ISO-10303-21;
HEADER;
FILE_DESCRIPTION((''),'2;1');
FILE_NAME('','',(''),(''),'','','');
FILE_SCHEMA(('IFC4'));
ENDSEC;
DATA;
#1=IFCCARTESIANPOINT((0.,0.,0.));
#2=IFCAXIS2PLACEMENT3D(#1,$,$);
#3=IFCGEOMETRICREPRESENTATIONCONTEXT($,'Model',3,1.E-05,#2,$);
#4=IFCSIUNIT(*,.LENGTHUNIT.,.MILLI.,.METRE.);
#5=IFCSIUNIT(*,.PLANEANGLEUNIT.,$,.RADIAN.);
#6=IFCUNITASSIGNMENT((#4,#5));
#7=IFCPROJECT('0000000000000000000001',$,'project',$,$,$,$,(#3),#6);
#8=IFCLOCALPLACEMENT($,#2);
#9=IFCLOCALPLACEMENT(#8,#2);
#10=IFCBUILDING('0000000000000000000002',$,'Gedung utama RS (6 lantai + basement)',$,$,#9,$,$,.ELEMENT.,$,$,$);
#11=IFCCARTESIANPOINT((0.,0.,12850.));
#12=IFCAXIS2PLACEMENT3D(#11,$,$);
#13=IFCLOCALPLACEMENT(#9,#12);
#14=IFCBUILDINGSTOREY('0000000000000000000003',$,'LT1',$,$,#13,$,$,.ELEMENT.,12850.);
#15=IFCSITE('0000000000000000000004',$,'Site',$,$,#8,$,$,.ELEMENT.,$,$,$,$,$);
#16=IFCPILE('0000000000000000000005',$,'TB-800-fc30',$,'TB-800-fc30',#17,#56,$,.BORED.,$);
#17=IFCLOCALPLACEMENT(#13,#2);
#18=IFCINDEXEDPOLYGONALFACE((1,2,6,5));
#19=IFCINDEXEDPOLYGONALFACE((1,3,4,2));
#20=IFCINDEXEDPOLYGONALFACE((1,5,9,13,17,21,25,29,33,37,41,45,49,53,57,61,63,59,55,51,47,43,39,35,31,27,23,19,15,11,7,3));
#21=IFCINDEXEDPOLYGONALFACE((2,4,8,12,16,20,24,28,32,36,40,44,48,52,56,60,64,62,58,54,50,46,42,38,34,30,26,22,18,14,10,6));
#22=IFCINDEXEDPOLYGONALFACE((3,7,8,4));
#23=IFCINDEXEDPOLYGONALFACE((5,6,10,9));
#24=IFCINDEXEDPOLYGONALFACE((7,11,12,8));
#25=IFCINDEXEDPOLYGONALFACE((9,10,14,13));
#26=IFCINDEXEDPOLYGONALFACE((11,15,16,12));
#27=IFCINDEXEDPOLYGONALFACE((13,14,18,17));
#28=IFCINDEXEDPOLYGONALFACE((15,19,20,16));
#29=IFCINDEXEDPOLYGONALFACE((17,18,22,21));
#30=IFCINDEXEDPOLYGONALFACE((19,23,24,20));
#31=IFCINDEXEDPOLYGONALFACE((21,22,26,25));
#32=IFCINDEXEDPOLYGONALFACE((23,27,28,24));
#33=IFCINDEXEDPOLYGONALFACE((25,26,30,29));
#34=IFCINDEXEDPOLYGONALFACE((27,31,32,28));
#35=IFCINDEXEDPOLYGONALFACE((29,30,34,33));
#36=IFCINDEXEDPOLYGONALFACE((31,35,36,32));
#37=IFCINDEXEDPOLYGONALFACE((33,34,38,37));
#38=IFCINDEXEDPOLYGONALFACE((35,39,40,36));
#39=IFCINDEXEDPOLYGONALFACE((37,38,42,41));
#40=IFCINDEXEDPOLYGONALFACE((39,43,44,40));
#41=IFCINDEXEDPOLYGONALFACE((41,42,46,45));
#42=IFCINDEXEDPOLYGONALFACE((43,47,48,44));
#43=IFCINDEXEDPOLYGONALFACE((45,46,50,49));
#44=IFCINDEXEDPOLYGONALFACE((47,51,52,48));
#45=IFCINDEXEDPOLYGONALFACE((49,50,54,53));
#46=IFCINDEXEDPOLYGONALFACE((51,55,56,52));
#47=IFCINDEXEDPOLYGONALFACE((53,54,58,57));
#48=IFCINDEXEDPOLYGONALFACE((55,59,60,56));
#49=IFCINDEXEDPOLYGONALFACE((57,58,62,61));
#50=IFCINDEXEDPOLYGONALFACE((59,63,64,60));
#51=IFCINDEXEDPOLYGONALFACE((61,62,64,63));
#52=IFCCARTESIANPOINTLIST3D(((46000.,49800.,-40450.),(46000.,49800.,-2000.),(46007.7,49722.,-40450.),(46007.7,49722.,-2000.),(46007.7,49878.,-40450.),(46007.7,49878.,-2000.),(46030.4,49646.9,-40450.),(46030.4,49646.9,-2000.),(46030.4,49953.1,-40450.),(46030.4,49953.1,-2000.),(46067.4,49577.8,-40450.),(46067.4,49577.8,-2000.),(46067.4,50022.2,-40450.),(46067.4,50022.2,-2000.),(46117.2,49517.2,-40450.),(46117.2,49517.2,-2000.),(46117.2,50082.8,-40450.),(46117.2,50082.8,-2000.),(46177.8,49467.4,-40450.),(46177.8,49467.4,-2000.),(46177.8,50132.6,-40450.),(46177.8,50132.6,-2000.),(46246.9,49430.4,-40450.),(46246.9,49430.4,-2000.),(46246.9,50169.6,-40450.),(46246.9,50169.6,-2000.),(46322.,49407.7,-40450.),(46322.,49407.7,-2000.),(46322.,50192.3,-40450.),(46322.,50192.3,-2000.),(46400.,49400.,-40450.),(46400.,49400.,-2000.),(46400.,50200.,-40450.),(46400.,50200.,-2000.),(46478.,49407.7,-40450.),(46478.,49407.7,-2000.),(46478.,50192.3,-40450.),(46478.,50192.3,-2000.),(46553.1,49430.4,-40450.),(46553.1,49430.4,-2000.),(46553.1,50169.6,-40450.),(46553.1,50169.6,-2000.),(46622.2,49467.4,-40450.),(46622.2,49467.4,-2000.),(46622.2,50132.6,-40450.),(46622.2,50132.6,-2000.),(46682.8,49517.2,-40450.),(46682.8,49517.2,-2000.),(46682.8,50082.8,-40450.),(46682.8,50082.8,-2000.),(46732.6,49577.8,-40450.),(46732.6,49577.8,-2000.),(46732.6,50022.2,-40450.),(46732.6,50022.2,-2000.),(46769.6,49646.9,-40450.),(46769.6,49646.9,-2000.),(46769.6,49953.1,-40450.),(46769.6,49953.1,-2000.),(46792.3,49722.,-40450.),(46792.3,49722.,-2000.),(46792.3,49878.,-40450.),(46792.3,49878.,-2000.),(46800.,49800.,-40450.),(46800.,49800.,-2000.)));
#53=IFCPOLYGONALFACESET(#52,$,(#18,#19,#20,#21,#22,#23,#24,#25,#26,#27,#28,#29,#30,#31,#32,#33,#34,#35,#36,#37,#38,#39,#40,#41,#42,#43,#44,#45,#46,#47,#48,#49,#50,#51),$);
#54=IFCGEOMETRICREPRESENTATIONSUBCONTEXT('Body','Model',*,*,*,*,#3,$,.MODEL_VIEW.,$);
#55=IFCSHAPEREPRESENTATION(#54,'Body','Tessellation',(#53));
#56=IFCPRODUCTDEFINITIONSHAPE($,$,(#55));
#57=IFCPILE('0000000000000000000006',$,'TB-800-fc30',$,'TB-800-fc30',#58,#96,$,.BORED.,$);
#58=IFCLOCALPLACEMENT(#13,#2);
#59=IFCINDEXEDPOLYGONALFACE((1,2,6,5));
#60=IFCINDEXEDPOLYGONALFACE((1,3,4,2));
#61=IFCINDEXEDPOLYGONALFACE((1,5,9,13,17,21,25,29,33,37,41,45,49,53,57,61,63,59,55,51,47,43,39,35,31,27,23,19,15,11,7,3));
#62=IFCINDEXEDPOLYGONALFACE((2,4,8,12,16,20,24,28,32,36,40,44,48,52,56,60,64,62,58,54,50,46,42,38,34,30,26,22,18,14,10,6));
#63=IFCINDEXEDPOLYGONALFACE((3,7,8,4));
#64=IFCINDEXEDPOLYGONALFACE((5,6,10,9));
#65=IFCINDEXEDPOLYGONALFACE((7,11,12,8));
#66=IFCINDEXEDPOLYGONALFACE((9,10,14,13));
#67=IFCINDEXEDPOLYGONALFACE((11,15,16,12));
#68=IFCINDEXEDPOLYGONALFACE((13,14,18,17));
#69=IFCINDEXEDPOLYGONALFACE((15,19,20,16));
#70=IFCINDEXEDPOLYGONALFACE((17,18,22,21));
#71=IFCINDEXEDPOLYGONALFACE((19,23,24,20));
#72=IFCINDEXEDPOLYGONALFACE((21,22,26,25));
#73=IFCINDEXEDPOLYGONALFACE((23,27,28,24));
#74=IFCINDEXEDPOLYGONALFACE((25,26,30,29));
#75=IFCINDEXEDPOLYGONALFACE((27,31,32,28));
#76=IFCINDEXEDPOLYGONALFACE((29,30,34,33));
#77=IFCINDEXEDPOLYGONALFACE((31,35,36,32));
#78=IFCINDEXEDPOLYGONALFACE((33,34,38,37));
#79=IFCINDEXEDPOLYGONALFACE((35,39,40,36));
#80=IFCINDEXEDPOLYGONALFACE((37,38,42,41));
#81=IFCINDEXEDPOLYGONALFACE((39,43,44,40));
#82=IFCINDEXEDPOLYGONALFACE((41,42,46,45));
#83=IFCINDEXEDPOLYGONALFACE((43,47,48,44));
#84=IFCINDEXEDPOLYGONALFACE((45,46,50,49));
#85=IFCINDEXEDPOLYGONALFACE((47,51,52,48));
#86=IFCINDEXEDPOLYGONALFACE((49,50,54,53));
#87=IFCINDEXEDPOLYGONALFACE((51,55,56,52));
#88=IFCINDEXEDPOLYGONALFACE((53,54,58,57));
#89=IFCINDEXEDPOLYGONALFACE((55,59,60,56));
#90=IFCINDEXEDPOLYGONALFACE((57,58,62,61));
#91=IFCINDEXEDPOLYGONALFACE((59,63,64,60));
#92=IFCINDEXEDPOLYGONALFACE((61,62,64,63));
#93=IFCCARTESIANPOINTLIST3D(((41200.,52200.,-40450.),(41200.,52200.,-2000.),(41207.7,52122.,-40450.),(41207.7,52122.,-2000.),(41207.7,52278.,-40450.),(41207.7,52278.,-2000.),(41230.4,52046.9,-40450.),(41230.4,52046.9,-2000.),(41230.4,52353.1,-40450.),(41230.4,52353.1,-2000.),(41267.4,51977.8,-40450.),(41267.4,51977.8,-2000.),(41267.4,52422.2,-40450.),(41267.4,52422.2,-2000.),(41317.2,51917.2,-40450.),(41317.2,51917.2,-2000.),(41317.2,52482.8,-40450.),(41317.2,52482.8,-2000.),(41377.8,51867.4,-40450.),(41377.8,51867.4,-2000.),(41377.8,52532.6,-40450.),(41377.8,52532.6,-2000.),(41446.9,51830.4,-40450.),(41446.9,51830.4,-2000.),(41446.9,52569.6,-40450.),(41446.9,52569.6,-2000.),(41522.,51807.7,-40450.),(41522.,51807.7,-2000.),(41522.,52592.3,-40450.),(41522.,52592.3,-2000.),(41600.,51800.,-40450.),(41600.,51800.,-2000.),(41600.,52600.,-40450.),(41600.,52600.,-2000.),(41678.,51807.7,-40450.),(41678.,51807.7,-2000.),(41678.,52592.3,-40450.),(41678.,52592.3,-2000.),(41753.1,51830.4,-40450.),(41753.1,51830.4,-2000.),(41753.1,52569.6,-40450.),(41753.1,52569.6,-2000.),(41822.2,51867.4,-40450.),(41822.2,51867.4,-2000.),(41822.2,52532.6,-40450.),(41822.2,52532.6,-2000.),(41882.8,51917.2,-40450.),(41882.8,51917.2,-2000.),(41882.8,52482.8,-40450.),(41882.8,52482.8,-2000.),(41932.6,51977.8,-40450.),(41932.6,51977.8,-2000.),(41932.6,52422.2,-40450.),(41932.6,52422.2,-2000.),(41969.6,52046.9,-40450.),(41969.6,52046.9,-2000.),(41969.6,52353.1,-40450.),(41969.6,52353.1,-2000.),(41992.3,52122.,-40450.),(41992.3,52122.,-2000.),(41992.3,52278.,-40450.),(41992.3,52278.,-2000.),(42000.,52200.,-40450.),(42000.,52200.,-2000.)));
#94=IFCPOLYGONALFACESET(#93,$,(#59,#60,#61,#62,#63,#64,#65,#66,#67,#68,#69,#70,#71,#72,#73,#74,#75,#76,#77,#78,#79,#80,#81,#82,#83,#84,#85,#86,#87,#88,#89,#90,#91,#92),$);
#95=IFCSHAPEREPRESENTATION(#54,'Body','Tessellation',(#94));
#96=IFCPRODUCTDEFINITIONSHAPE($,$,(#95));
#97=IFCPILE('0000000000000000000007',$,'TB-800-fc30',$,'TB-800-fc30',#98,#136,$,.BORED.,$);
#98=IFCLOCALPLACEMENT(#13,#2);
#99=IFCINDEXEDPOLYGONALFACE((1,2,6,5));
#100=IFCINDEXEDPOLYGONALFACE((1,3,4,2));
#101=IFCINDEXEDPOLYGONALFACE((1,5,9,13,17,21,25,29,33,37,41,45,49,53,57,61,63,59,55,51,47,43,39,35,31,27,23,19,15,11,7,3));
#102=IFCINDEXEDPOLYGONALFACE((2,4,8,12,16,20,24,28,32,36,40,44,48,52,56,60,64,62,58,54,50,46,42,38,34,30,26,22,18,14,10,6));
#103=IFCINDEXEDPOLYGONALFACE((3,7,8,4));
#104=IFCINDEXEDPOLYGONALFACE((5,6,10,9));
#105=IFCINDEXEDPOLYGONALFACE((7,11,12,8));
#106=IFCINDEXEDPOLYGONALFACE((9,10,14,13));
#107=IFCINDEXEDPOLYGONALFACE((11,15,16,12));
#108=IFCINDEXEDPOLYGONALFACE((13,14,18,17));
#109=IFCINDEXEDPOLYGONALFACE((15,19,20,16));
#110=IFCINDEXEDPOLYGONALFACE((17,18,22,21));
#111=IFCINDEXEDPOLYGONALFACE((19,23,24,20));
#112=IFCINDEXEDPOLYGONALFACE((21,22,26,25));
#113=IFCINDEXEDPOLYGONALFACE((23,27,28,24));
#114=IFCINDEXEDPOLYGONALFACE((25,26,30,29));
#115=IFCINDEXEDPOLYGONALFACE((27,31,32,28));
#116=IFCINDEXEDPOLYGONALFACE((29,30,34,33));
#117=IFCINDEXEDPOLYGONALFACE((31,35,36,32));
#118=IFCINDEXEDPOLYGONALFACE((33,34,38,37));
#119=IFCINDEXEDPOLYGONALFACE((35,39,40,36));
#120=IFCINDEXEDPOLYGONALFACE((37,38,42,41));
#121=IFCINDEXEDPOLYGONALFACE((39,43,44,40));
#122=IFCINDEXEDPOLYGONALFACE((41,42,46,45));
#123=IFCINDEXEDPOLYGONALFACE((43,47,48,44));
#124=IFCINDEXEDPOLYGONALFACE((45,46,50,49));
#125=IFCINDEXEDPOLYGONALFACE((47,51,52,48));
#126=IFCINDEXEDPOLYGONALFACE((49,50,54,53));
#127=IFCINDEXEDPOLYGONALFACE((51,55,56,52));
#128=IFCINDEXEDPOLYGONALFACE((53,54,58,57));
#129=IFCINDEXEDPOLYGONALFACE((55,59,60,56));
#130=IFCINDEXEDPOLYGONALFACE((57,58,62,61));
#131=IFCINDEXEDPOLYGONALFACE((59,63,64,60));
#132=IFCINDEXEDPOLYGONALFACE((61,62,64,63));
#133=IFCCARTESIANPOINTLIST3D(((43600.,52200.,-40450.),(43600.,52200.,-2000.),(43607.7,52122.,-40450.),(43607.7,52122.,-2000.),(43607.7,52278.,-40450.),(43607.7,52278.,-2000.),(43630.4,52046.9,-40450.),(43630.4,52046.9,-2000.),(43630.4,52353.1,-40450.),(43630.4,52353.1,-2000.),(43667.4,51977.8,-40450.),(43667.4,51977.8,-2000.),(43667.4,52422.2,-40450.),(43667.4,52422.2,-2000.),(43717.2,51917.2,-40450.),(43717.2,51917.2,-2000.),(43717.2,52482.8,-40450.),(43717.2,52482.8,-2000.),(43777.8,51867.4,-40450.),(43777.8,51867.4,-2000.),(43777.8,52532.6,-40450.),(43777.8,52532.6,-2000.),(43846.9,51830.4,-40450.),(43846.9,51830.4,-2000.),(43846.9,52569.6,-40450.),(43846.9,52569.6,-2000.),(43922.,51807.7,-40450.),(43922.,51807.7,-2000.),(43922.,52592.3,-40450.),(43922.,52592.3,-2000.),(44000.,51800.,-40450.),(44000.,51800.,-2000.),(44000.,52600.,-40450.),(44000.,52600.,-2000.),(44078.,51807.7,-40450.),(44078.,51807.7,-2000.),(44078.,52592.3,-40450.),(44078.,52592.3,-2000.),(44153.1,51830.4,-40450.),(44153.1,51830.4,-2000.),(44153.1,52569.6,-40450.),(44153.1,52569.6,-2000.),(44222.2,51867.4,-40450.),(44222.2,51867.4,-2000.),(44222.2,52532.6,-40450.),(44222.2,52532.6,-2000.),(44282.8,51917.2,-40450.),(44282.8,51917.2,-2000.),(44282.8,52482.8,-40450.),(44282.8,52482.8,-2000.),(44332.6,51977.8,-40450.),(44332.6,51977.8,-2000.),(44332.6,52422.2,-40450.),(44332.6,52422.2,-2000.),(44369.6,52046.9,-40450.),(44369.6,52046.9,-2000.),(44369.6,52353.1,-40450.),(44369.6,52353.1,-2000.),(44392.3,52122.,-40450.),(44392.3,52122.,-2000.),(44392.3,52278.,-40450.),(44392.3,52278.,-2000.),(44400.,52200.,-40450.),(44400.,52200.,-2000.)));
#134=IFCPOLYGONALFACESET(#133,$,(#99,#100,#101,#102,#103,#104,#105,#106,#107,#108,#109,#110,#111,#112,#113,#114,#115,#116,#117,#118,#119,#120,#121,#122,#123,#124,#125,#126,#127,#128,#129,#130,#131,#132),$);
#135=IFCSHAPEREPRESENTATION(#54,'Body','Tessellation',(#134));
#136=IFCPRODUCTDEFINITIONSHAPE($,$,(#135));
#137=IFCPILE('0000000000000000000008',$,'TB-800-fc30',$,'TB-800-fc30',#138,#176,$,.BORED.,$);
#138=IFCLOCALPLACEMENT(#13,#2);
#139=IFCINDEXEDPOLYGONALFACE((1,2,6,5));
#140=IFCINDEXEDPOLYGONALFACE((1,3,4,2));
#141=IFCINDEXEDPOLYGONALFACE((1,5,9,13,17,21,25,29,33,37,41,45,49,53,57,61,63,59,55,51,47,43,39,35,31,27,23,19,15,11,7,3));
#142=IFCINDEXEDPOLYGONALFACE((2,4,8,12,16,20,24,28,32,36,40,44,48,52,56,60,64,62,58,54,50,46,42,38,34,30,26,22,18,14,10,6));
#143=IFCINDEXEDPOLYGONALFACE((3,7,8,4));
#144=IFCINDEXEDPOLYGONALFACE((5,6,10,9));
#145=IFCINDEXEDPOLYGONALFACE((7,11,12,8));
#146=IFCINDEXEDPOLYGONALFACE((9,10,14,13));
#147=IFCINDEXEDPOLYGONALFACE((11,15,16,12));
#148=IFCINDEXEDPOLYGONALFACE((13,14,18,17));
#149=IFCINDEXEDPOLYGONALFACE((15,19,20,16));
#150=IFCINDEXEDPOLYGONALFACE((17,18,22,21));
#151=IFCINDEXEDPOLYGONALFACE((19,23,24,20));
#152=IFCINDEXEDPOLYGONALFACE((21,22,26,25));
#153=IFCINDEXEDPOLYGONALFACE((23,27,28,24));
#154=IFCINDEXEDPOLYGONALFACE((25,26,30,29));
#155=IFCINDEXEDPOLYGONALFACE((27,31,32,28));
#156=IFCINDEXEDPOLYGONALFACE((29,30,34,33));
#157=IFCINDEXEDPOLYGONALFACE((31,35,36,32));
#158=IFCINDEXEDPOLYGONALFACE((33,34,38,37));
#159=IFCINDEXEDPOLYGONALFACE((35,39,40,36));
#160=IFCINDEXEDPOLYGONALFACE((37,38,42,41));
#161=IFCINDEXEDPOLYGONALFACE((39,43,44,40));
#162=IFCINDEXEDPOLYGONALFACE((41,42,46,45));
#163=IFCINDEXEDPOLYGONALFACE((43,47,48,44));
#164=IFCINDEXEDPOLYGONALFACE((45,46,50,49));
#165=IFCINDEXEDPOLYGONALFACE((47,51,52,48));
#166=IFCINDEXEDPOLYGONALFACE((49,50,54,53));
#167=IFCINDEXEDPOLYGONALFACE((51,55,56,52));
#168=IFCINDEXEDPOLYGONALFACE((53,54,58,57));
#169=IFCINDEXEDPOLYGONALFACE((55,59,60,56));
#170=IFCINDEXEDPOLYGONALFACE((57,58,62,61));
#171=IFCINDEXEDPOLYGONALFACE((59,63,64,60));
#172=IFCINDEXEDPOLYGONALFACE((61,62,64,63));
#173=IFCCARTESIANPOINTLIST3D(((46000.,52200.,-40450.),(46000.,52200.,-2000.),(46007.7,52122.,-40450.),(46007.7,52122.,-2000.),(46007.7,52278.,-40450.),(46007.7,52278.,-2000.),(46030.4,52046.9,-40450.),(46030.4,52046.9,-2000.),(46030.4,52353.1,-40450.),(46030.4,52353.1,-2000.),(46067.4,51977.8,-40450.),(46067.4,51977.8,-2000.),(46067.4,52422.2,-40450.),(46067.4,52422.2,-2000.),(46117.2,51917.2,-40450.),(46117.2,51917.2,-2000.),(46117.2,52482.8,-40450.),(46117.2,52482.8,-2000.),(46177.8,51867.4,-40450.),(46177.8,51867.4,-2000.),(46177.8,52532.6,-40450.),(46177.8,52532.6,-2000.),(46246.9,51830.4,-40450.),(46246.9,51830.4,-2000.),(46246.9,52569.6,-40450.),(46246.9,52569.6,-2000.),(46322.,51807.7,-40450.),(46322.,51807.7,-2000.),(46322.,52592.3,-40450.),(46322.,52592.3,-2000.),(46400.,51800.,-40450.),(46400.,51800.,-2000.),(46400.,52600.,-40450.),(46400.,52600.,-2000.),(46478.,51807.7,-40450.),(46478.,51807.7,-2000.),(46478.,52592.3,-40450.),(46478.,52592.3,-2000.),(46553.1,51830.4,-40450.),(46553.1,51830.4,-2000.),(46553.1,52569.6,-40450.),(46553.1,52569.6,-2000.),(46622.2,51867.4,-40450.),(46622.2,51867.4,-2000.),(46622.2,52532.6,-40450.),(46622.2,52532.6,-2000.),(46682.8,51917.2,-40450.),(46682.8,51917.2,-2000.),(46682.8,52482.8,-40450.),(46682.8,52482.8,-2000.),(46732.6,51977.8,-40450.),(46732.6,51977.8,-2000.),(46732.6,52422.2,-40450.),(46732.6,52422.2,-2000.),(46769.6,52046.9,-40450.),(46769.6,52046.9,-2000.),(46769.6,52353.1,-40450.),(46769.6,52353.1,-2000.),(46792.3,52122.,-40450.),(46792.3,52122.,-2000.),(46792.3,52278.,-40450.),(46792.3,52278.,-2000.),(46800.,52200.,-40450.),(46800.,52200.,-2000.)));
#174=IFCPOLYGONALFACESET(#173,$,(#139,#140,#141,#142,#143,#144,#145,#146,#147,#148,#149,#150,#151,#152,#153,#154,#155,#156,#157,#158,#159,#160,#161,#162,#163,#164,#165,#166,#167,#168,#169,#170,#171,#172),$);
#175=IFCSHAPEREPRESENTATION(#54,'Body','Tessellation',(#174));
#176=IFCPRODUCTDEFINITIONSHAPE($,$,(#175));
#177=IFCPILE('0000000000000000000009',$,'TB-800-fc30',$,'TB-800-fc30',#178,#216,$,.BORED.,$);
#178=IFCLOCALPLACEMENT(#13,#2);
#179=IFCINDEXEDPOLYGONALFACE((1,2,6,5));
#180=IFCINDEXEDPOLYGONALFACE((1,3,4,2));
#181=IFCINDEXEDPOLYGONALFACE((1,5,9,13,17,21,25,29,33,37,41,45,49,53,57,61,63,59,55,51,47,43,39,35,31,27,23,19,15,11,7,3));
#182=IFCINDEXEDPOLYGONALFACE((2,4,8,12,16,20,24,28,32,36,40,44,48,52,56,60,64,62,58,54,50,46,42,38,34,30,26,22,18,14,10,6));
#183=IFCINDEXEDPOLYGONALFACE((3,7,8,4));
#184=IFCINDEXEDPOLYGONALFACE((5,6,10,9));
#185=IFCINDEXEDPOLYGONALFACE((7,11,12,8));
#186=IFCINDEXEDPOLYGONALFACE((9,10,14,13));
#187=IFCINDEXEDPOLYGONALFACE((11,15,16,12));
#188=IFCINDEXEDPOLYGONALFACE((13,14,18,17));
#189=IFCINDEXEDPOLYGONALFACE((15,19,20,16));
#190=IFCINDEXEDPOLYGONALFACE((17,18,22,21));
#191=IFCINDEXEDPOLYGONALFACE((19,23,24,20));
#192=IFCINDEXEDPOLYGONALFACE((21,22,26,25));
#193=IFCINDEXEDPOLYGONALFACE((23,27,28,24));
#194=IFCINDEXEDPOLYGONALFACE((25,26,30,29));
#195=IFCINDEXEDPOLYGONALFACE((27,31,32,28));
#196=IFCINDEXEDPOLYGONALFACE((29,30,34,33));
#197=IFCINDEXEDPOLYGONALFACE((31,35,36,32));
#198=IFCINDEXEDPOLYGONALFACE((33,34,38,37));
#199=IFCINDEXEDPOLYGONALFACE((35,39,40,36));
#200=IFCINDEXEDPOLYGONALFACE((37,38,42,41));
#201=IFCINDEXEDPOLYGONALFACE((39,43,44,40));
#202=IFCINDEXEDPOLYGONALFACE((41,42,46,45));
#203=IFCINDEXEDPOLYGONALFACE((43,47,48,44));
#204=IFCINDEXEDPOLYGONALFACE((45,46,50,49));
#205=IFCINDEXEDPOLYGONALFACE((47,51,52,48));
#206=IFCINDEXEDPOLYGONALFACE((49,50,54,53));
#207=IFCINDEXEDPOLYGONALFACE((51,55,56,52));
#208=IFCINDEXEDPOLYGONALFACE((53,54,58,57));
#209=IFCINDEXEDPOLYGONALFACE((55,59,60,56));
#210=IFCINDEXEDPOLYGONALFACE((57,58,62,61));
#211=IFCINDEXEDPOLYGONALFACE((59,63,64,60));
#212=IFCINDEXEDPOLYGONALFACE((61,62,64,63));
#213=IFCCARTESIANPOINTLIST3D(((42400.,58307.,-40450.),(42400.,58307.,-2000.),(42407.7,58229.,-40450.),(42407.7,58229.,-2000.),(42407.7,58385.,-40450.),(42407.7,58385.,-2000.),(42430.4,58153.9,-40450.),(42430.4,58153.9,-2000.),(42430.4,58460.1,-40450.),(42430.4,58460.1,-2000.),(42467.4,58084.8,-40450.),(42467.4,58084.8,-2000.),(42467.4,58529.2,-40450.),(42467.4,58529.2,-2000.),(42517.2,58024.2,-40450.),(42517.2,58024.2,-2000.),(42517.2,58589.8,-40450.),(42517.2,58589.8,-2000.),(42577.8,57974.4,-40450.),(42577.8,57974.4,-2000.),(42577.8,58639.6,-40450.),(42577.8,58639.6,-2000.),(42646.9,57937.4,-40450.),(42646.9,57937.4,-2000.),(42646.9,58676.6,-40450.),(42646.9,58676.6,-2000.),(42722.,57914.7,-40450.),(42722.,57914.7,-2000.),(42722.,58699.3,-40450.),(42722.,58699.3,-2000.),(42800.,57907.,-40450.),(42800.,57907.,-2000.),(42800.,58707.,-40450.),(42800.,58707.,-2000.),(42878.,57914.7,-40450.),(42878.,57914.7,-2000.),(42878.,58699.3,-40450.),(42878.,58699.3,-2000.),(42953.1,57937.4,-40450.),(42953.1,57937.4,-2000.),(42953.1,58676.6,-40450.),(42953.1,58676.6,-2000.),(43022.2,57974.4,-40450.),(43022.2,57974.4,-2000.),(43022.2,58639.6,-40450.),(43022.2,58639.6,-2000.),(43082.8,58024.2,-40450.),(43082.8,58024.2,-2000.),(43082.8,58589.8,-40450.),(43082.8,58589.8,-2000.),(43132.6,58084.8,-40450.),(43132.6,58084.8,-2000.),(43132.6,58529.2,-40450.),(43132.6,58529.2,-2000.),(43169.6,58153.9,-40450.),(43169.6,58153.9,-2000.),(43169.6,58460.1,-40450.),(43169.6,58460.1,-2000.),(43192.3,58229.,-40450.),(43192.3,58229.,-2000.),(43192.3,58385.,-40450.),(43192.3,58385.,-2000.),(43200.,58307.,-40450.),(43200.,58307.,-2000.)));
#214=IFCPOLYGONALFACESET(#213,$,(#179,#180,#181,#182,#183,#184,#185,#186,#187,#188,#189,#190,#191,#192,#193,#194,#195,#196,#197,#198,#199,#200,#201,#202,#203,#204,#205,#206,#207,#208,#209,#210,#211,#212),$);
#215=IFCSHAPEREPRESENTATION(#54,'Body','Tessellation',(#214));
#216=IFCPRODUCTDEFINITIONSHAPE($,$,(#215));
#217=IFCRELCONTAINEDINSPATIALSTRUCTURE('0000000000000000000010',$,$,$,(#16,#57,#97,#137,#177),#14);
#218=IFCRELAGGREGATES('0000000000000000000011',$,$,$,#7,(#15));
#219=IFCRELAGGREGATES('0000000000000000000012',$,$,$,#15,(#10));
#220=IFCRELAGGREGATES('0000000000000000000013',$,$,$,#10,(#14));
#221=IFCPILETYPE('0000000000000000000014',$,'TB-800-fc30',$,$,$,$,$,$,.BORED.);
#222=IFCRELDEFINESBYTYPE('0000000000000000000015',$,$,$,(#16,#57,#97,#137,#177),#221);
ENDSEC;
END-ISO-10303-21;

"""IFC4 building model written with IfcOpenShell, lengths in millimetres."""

from ifc_helpers import new_model, si_unit, frame, origin, origin_2d, place, context, subcontext, project, spatial, circle, extrude, material_profile, profile_set, profile_usage, type_object, element, save


model = new_model("IFC4")

# Units and contexts
model_context = context("Model", 3, precision=1e-05, world=origin())
body_context = subcontext(model_context, "Body", "Model", "MODEL_VIEW")
ifc_project = project(units=[si_unit("LENGTHUNIT", "METRE", prefix="MILLI"), si_unit("PLANEANGLEUNIT", "RADIAN")], contexts=[model_context])

# Site, building, storey
site_placement = place(None, origin())
site = spatial("IfcSite", under=ifc_project, at=site_placement, Name="Site", CompositionType="ELEMENT")
building_placement = place(site_placement, origin())
building = spatial("IfcBuilding", under=site, at=building_placement, Name="Gedung utama RS (6 lantai + basement)", CompositionType="ELEMENT")
storey_placement = place(building_placement, frame((0.0, 0.0, 12850.0)))
storey = spatial("IfcBuildingStorey", under=building, at=storey_placement, Name="LT1", CompositionType="ELEMENT", Elevation=12850.0)

# Piles
ifc_material_profile = material_profile(None, circle(Radius=400.0, at=origin_2d()), Name="TB-800-fc30")
ifc_profile_set = profile_set([ifc_material_profile], Name="TB-800-fc30")
ifc_profile_usage = profile_usage(ifc_profile_set, cardinal=5)
pile_type = type_object("IfcPileType", Name="TB-800-fc30", PredefinedType="BORED", material=ifc_profile_set)
for number, where, z_axis, x_axis, name in (
    (1, (46400.0, 49800.0, -40450.0), (0.0, 0.0, 1.0), (1.0, 0.0, 0.0), "TB-800-fc30"),
    (2, (41600.0, 52200.0, -40450.0), (0.0, 0.0, 1.0), (1.0, 0.0, 0.0), "TB-800-fc30"),
    (3, (44000.0, 52200.0, -40450.0), (0.0, 0.0, 1.0), (1.0, 0.0, 0.0), "TB-800-fc30"),
    (4, (46400.0, 52200.0, -40450.0), (0.0, 0.0, 1.0), (1.0, 0.0, 0.0), "TB-800-fc30"),
    (5, (42800.0, 58307.0, -40450.0), (0.0, 0.0, 1.0), (1.0, 0.0, 0.0), "TB-800-fc30"),
):
    element("IfcPile", number, at=place(storey_placement, frame(where, z_axis=z_axis, x_axis=x_axis)), inside=storey, type_object=pile_type, material=ifc_profile_usage, Name=name, ObjectType="TB-800-fc30", PredefinedType="BORED", context=body_context, shape_type="SweptSolid", body=[
        extrude(circle(Radius=400.0, at=origin_2d()), origin(), (0.0, 0.0, 1.0), 38450.0),
    ])

save(model, "model.ifc")
